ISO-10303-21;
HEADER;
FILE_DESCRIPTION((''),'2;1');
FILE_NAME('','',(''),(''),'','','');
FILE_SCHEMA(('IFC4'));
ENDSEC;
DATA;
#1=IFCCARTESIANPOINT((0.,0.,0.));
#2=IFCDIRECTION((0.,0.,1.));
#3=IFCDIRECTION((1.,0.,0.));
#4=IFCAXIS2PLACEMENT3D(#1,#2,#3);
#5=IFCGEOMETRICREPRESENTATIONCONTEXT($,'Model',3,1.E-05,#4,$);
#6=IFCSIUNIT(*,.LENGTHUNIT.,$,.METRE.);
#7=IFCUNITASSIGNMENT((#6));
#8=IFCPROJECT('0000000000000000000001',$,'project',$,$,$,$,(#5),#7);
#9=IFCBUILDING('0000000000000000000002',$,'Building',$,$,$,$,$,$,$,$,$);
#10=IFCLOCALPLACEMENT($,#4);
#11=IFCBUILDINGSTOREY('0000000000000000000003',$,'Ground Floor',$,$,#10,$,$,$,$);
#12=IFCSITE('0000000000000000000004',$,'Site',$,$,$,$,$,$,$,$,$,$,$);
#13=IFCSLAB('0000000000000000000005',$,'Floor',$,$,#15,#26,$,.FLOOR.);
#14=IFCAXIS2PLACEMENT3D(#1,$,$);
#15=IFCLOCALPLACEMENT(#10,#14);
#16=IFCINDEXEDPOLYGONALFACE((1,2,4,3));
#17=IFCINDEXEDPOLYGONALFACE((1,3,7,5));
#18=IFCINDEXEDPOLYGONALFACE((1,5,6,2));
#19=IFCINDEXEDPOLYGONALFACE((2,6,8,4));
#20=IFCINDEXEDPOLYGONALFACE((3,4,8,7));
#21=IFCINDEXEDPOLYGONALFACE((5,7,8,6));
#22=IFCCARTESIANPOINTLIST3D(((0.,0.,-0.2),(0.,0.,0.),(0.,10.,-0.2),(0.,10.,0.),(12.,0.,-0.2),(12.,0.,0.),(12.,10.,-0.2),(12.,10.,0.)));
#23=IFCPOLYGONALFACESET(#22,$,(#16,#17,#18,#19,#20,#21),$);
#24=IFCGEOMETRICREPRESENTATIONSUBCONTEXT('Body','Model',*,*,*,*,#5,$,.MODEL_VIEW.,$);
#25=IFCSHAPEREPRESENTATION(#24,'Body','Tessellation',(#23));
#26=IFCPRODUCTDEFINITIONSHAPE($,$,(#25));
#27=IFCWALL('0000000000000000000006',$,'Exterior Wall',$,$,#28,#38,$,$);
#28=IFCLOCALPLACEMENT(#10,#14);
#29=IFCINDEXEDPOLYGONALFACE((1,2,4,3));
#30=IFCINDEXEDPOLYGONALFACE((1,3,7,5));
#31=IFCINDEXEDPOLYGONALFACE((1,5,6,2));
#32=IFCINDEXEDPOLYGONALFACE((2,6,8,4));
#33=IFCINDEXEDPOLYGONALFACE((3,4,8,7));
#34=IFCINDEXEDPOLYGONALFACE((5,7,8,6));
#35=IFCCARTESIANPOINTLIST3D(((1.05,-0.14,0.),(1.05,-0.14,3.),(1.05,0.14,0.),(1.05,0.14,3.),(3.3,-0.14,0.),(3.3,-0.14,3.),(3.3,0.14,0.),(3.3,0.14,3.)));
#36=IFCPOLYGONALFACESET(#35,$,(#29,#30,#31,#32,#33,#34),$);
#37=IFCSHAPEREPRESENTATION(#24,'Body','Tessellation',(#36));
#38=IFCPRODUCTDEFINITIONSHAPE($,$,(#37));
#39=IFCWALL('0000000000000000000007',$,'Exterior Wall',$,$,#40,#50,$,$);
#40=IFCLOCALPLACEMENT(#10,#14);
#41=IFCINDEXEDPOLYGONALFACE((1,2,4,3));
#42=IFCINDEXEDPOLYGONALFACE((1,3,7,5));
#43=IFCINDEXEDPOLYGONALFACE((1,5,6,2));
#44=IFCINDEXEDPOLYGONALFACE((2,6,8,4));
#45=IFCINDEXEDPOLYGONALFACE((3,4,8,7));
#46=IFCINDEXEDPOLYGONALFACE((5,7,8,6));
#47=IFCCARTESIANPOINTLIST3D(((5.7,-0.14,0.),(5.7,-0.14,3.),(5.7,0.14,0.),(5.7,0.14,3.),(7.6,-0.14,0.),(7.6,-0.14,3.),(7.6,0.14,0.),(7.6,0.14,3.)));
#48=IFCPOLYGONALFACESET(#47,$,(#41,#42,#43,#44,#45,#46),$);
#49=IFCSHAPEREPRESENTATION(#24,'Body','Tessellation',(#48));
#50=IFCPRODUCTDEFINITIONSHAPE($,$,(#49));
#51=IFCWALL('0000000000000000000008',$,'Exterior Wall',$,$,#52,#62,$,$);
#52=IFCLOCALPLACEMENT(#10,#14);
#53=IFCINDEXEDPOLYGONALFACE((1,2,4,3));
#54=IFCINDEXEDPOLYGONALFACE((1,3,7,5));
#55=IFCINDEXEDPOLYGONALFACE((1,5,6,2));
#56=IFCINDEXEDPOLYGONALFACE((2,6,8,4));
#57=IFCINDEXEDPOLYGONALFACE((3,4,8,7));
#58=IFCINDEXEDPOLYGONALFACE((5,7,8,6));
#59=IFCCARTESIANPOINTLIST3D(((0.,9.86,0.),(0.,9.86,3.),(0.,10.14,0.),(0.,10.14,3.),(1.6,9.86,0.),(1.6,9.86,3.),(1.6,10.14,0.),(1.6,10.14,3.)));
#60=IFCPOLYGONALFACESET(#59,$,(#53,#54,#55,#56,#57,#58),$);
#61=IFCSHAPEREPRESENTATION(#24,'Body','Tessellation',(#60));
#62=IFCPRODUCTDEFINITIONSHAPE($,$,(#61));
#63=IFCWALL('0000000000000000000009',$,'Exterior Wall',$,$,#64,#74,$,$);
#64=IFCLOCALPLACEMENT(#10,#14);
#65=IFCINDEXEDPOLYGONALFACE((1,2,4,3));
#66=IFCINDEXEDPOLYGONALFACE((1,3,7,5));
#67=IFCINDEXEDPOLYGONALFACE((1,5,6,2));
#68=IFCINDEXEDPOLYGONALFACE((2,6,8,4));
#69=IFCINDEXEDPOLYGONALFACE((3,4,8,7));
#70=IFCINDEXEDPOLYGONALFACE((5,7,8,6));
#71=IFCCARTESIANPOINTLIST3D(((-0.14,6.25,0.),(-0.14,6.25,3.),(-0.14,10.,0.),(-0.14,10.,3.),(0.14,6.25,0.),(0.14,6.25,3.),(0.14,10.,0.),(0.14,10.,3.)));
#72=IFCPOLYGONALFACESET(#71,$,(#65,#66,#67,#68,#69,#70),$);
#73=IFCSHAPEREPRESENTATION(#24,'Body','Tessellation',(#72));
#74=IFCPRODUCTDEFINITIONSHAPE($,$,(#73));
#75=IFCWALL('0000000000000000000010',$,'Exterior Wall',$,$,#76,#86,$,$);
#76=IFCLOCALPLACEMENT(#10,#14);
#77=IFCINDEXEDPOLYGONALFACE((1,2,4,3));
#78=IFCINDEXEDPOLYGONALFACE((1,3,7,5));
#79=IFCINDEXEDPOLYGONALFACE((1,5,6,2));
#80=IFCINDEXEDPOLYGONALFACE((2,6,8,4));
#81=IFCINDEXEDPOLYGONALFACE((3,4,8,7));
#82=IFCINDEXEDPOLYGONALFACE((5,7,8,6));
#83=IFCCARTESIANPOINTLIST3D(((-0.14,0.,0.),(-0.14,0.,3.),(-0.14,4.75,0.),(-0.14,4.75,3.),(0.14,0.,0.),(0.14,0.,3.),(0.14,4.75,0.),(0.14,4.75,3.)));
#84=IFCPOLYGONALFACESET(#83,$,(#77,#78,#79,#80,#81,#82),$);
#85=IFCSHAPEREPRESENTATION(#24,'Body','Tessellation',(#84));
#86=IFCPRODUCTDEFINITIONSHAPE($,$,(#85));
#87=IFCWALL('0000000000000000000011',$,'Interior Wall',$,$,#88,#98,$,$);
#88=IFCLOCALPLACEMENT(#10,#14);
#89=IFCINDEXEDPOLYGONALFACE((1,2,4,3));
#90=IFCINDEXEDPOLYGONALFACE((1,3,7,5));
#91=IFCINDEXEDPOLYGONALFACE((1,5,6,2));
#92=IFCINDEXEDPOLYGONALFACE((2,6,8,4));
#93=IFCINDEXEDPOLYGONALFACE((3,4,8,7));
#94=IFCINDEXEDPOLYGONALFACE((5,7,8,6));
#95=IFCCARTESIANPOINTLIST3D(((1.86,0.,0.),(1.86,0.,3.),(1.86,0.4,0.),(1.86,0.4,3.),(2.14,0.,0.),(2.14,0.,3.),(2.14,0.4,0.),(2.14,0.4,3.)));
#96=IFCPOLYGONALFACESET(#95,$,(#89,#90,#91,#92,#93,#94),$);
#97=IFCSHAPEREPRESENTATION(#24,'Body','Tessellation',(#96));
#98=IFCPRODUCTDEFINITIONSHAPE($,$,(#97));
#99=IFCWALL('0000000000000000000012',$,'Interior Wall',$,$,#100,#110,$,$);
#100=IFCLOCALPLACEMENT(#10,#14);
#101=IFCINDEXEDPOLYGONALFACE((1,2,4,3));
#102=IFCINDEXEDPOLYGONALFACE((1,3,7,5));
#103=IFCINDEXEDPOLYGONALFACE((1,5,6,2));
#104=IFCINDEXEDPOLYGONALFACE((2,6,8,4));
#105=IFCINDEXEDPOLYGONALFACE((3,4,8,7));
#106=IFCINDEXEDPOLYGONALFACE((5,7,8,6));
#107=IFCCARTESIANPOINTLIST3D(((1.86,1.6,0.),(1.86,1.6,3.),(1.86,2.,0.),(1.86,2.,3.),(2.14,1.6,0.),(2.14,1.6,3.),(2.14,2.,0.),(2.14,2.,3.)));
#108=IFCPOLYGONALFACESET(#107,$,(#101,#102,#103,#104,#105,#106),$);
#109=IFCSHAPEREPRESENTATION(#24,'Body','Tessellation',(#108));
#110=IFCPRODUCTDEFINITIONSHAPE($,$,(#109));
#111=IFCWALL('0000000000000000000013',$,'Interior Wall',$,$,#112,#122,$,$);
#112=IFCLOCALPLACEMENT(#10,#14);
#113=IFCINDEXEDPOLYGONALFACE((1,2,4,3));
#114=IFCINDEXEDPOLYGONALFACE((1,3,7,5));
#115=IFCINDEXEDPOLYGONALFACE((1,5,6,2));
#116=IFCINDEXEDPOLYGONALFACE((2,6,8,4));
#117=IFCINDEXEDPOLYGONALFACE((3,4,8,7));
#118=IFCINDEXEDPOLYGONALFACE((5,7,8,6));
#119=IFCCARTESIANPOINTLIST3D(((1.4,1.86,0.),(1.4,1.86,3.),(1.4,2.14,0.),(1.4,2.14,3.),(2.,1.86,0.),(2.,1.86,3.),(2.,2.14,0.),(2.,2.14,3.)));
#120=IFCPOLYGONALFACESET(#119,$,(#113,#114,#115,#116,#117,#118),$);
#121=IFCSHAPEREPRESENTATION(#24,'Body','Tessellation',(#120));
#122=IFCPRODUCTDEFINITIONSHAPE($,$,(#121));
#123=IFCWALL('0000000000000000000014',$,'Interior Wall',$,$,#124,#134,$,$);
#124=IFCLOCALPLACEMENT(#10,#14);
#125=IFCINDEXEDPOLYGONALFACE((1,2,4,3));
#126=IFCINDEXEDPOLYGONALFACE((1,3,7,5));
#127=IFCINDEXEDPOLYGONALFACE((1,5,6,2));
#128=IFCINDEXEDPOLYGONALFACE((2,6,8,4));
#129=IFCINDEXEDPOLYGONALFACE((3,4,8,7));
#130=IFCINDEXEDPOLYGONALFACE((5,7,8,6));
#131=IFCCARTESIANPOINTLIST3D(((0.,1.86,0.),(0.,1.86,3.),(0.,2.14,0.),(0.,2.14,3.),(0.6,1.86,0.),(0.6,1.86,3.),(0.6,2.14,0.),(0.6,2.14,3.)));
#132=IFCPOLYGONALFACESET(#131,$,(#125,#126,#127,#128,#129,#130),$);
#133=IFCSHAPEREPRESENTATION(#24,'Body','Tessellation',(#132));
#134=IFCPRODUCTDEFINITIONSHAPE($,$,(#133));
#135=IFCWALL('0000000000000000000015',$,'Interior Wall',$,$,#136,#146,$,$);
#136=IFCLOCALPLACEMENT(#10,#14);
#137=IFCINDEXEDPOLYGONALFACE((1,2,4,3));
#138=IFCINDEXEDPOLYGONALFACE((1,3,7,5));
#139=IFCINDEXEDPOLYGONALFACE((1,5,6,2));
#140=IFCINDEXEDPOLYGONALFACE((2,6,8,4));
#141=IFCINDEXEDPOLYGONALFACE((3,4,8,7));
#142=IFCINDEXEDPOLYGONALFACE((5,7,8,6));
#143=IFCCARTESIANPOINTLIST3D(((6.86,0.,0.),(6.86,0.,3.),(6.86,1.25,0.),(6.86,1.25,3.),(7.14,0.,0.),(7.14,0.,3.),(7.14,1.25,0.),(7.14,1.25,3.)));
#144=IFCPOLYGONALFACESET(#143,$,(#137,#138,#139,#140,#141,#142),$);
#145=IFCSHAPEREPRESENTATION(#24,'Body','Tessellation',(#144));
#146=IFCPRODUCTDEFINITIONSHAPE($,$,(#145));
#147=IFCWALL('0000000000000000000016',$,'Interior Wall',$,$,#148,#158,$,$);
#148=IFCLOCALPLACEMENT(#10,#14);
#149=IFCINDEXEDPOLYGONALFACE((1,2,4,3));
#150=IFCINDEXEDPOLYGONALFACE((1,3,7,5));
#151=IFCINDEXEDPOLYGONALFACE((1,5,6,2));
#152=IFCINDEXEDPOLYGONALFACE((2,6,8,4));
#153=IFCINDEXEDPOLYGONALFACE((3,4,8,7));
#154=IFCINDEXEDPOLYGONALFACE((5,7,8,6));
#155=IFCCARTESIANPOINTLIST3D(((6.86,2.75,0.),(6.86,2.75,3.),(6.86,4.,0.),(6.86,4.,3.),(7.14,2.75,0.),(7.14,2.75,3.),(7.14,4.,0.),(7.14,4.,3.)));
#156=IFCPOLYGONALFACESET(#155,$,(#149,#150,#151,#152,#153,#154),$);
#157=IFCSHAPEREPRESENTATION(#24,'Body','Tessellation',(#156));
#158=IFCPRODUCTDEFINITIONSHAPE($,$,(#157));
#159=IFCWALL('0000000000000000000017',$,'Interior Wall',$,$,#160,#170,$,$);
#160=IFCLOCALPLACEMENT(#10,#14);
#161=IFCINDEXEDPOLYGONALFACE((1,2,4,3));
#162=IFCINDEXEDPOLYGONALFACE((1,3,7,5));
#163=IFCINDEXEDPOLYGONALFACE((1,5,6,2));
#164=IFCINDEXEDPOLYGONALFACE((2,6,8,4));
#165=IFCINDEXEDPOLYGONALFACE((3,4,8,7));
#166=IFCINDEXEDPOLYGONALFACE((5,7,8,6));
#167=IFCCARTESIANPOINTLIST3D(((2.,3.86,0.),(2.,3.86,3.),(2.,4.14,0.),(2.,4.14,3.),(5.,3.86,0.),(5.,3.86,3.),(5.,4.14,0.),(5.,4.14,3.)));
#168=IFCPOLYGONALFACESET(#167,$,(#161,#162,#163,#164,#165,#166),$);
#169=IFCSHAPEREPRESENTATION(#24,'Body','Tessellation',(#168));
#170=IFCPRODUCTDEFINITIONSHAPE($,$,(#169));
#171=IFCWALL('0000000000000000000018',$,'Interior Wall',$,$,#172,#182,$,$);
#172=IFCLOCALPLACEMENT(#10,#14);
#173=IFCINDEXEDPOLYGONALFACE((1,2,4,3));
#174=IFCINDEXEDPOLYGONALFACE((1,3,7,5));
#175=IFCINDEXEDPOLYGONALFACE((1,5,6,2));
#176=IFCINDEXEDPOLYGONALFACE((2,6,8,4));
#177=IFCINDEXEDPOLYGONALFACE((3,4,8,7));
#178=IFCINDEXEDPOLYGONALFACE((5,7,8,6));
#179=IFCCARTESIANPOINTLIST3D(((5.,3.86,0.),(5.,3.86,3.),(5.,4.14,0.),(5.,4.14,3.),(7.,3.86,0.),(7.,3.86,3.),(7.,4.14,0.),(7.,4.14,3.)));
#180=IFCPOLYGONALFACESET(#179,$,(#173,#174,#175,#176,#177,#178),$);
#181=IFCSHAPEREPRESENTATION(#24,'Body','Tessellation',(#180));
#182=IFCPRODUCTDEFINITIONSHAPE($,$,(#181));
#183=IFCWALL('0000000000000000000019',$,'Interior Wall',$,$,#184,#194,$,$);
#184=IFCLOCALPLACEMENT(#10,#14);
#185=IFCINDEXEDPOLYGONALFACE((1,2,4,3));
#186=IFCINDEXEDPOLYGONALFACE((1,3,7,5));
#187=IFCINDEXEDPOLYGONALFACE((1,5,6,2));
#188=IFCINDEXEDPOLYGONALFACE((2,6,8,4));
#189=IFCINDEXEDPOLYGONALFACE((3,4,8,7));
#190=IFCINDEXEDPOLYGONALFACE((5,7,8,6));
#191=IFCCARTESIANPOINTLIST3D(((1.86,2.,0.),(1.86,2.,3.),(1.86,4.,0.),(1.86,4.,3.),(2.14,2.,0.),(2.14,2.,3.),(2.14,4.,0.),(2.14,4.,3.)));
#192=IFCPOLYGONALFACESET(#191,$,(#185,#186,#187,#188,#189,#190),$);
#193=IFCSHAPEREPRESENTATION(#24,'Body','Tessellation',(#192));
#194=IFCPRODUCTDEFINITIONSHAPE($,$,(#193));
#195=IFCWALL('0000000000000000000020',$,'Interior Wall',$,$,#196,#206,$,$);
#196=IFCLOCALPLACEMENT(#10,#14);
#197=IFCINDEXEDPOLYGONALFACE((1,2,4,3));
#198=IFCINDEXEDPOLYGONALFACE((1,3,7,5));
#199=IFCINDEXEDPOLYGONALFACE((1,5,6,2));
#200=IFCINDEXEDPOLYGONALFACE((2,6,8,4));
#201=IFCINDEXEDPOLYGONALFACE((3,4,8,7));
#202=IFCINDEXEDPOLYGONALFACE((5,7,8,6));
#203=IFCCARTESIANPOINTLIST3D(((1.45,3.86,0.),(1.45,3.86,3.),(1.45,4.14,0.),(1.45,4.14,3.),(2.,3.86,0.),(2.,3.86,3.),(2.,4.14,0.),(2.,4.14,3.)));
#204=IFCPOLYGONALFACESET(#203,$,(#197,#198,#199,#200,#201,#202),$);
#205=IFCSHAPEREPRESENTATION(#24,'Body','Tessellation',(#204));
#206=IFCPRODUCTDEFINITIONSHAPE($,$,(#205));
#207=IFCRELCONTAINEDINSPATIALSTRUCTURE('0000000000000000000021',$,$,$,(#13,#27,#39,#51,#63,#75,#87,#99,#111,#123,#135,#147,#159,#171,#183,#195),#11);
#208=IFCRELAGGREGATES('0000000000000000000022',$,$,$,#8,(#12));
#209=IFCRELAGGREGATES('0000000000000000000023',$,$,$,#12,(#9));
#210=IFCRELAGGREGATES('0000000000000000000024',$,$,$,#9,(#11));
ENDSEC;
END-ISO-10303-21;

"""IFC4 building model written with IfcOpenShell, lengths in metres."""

from ifc_helpers import new_model, si_unit, frame, origin_with_axes, place, context, subcontext, project, spatial, indexed_curve, outline, extrude, element, save


model = new_model("IFC4")

# Units and contexts
model_context = context("Model", 3, precision=1e-05, world=origin_with_axes())
body_context = subcontext(model_context, "Body", "Model", "MODEL_VIEW")
ifc_project = project(units=[si_unit("LENGTHUNIT", "METRE")], contexts=[model_context])

# Site, building, storey
site = spatial("IfcSite", under=ifc_project, Name="Site")
building = spatial("IfcBuilding", under=site, Name="Building")
storey_placement = place(None, origin_with_axes())
storey = spatial("IfcBuildingStorey", under=building, at=storey_placement, Name="Ground Floor")

# Slab
slab_placement = place(storey_placement, frame((0.0, 0.0, -0.2), z_axis=(0.0, 0.0, 1.0), x_axis=(1.0, 0.0, 0.0)))
element("IfcSlab", 1, at=slab_placement, inside=storey, Name="Floor", PredefinedType="FLOOR", context=body_context, shape_type="SweptSolid", body=[
    extrude(outline(indexed_curve([(0.0, 0.0), (12.0, 0.0), (12.0, 10.0), (0.0, 10.0)])), None, (0.0, 0.0, 1.0), 0.2),
])

# Walls
wall_1_placement = place(storey_placement, frame((1.05, 0.0, 0.0), z_axis=(0.0, 0.0, 1.0), x_axis=(1.0, 0.0, 0.0)))
element("IfcWall", 2, at=wall_1_placement, inside=storey, Name="Exterior Wall", context=body_context, shape_type="SweptSolid", body=[
    extrude(outline(indexed_curve([(0.0, 0.0), (0.0, 0.28), (2.25, 0.28), (2.25, 0.0), (0.0, 0.0)], self_intersect=False)), frame((0.0, -0.14, 0.0), z_axis=(0.0, 0.0, 1.0), x_axis=(1.0, 0.0, 0.0)), (0.0, 0.0, 1.0), 3.0),
])
wall_2_placement = place(storey_placement, frame((5.7, 0.0, 0.0), z_axis=(0.0, 0.0, 1.0), x_axis=(1.0, 0.0, 0.0)))
element("IfcWall", 3, at=wall_2_placement, inside=storey, Name="Exterior Wall", context=body_context, shape_type="SweptSolid", body=[
    extrude(outline(indexed_curve([(0.0, 0.0), (0.0, 0.28), (1.9, 0.28), (1.9, 0.0), (0.0, 0.0)], self_intersect=False)), frame((0.0, -0.14, 0.0), z_axis=(0.0, 0.0, 1.0), x_axis=(1.0, 0.0, 0.0)), (0.0, 0.0, 1.0), 3.0),
])
wall_3_placement = place(storey_placement, frame((1.6, 10.0, 0.0), z_axis=(0.0, 0.0, 1.0), x_axis=(-1.0, 0.0, 0.0)))
element("IfcWall", 4, at=wall_3_placement, inside=storey, Name="Exterior Wall", context=body_context, shape_type="SweptSolid", body=[
    extrude(outline(indexed_curve([(0.0, 0.0), (0.0, 0.28), (1.6, 0.28), (1.6, 0.0), (0.0, 0.0)], self_intersect=False)), frame((0.0, -0.14, 0.0), z_axis=(0.0, 0.0, 1.0), x_axis=(1.0, 0.0, 0.0)), (0.0, 0.0, 1.0), 3.0),
])
wall_4_placement = place(storey_placement, frame((0.0, 10.0, 0.0), z_axis=(0.0, 0.0, 1.0), x_axis=(0.0, -1.0, 0.0)))
element("IfcWall", 5, at=wall_4_placement, inside=storey, Name="Exterior Wall", context=body_context, shape_type="SweptSolid", body=[
    extrude(outline(indexed_curve([(0.0, 0.0), (0.0, 0.28), (3.75, 0.28), (3.75, 0.0), (0.0, 0.0)], self_intersect=False)), frame((0.0, -0.14, 0.0), z_axis=(0.0, 0.0, 1.0), x_axis=(1.0, 0.0, 0.0)), (0.0, 0.0, 1.0), 3.0),
])
wall_5_placement = place(storey_placement, frame((0.0, 4.75, 0.0), z_axis=(0.0, 0.0, 1.0), x_axis=(0.0, -1.0, 0.0)))
element("IfcWall", 6, at=wall_5_placement, inside=storey, Name="Exterior Wall", context=body_context, shape_type="SweptSolid", body=[
    extrude(outline(indexed_curve([(0.0, 0.0), (0.0, 0.28), (4.75, 0.28), (4.75, 0.0), (0.0, 0.0)], self_intersect=False)), frame((0.0, -0.14, 0.0), z_axis=(0.0, 0.0, 1.0), x_axis=(1.0, 0.0, 0.0)), (0.0, 0.0, 1.0), 3.0),
])
wall_6_placement = place(storey_placement, frame((2.0, 0.0, 0.0), z_axis=(0.0, 0.0, 1.0), x_axis=(0.0, 1.0, 0.0)))
element("IfcWall", 7, at=wall_6_placement, inside=storey, Name="Interior Wall", context=body_context, shape_type="SweptSolid", body=[
    extrude(outline(indexed_curve([(0.0, 0.0), (0.0, 0.28), (0.4, 0.28), (0.4, 0.0), (0.0, 0.0)], self_intersect=False)), frame((0.0, -0.14, 0.0), z_axis=(0.0, 0.0, 1.0), x_axis=(1.0, 0.0, 0.0)), (0.0, 0.0, 1.0), 3.0),
])
wall_7_placement = place(storey_placement, frame((2.0, 1.6, 0.0), z_axis=(0.0, 0.0, 1.0), x_axis=(0.0, 1.0, 0.0)))
element("IfcWall", 8, at=wall_7_placement, inside=storey, Name="Interior Wall", context=body_context, shape_type="SweptSolid", body=[
    extrude(outline(indexed_curve([(0.0, 0.0), (0.0, 0.28), (0.4, 0.28), (0.4, 0.0), (0.0, 0.0)], self_intersect=False)), frame((0.0, -0.14, 0.0), z_axis=(0.0, 0.0, 1.0), x_axis=(1.0, 0.0, 0.0)), (0.0, 0.0, 1.0), 3.0),
])
for number, where, z_axis, x_axis, name in (
    (9, (2.0, 2.0, 0.0), (0.0, 0.0, 1.0), (-1.0, 0.0, 0.0), "Interior Wall"),
    (10, (0.6, 2.0, 0.0), (0.0, 0.0, 1.0), (-1.0, 0.0, 0.0), "Interior Wall"),
):
    element("IfcWall", number, at=place(storey_placement, frame(where, z_axis=z_axis, x_axis=x_axis)), inside=storey, Name=name, context=body_context, shape_type="SweptSolid", body=[
        extrude(outline(indexed_curve([(0.0, 0.0), (0.0, 0.28), (0.6, 0.28), (0.6, 0.0), (0.0, 0.0)], self_intersect=False)), frame((0.0, -0.14, 0.0), z_axis=(0.0, 0.0, 1.0), x_axis=(1.0, 0.0, 0.0)), (0.0, 0.0, 1.0), 3.0),
    ])
for number, where, z_axis, x_axis, name in (
    (11, (7.0, 0.0, 0.0), (0.0, 0.0, 1.0), (0.0, 1.0, 0.0), "Interior Wall"),
    (12, (7.0, 2.75, 0.0), (0.0, 0.0, 1.0), (0.0, 1.0, 0.0), "Interior Wall"),
):
    element("IfcWall", number, at=place(storey_placement, frame(where, z_axis=z_axis, x_axis=x_axis)), inside=storey, Name=name, context=body_context, shape_type="SweptSolid", body=[
        extrude(outline(indexed_curve([(0.0, 0.0), (0.0, 0.28), (1.25, 0.28), (1.25, 0.0), (0.0, 0.0)], self_intersect=False)), frame((0.0, -0.14, 0.0), z_axis=(0.0, 0.0, 1.0), x_axis=(1.0, 0.0, 0.0)), (0.0, 0.0, 1.0), 3.0),
    ])
wall_8_placement = place(storey_placement, frame((5.0, 4.0, 0.0), z_axis=(0.0, 0.0, 1.0), x_axis=(-1.0, 0.0, 0.0)))
element("IfcWall", 13, at=wall_8_placement, inside=storey, Name="Interior Wall", context=body_context, shape_type="SweptSolid", body=[
    extrude(outline(indexed_curve([(0.0, 0.0), (0.0, 0.28), (3.0, 0.28), (3.0, 0.0), (0.0, 0.0)], self_intersect=False)), frame((0.0, -0.14, 0.0), z_axis=(0.0, 0.0, 1.0), x_axis=(1.0, 0.0, 0.0)), (0.0, 0.0, 1.0), 3.0),
])
for number, where, z_axis, x_axis, name in (
    (14, (7.0, 4.0, 0.0), (0.0, 0.0, 1.0), (-1.0, 0.0, 0.0), "Interior Wall"),
    (15, (2.0, 4.0, 0.0), (0.0, 0.0, 1.0), (0.0, -1.0, 0.0), "Interior Wall"),
):
    element("IfcWall", number, at=place(storey_placement, frame(where, z_axis=z_axis, x_axis=x_axis)), inside=storey, Name=name, context=body_context, shape_type="SweptSolid", body=[
        extrude(outline(indexed_curve([(0.0, 0.0), (0.0, 0.28), (2.0, 0.28), (2.0, 0.0), (0.0, 0.0)], self_intersect=False)), frame((0.0, -0.14, 0.0), z_axis=(0.0, 0.0, 1.0), x_axis=(1.0, 0.0, 0.0)), (0.0, 0.0, 1.0), 3.0),
    ])
for number, where, z_axis, x_axis, name in (
    (16, (2.0, 4.0, 0.0), (0.0, 0.0, 1.0), (-1.0, 0.0, 0.0), "Interior Wall"),
):
    element("IfcWall", number, at=place(storey_placement, frame(where, z_axis=z_axis, x_axis=x_axis)), inside=storey, Name=name, context=body_context, shape_type="SweptSolid", body=[
        extrude(outline(indexed_curve([(0.0, 0.0), (0.0, 0.28), (0.55, 0.28), (0.55, 0.0), (0.0, 0.0)], self_intersect=False)), frame((0.0, -0.14, 0.0), z_axis=(0.0, 0.0, 1.0), x_axis=(1.0, 0.0, 0.0)), (0.0, 0.0, 1.0), 3.0),
    ])

save(model, "model.ifc")
